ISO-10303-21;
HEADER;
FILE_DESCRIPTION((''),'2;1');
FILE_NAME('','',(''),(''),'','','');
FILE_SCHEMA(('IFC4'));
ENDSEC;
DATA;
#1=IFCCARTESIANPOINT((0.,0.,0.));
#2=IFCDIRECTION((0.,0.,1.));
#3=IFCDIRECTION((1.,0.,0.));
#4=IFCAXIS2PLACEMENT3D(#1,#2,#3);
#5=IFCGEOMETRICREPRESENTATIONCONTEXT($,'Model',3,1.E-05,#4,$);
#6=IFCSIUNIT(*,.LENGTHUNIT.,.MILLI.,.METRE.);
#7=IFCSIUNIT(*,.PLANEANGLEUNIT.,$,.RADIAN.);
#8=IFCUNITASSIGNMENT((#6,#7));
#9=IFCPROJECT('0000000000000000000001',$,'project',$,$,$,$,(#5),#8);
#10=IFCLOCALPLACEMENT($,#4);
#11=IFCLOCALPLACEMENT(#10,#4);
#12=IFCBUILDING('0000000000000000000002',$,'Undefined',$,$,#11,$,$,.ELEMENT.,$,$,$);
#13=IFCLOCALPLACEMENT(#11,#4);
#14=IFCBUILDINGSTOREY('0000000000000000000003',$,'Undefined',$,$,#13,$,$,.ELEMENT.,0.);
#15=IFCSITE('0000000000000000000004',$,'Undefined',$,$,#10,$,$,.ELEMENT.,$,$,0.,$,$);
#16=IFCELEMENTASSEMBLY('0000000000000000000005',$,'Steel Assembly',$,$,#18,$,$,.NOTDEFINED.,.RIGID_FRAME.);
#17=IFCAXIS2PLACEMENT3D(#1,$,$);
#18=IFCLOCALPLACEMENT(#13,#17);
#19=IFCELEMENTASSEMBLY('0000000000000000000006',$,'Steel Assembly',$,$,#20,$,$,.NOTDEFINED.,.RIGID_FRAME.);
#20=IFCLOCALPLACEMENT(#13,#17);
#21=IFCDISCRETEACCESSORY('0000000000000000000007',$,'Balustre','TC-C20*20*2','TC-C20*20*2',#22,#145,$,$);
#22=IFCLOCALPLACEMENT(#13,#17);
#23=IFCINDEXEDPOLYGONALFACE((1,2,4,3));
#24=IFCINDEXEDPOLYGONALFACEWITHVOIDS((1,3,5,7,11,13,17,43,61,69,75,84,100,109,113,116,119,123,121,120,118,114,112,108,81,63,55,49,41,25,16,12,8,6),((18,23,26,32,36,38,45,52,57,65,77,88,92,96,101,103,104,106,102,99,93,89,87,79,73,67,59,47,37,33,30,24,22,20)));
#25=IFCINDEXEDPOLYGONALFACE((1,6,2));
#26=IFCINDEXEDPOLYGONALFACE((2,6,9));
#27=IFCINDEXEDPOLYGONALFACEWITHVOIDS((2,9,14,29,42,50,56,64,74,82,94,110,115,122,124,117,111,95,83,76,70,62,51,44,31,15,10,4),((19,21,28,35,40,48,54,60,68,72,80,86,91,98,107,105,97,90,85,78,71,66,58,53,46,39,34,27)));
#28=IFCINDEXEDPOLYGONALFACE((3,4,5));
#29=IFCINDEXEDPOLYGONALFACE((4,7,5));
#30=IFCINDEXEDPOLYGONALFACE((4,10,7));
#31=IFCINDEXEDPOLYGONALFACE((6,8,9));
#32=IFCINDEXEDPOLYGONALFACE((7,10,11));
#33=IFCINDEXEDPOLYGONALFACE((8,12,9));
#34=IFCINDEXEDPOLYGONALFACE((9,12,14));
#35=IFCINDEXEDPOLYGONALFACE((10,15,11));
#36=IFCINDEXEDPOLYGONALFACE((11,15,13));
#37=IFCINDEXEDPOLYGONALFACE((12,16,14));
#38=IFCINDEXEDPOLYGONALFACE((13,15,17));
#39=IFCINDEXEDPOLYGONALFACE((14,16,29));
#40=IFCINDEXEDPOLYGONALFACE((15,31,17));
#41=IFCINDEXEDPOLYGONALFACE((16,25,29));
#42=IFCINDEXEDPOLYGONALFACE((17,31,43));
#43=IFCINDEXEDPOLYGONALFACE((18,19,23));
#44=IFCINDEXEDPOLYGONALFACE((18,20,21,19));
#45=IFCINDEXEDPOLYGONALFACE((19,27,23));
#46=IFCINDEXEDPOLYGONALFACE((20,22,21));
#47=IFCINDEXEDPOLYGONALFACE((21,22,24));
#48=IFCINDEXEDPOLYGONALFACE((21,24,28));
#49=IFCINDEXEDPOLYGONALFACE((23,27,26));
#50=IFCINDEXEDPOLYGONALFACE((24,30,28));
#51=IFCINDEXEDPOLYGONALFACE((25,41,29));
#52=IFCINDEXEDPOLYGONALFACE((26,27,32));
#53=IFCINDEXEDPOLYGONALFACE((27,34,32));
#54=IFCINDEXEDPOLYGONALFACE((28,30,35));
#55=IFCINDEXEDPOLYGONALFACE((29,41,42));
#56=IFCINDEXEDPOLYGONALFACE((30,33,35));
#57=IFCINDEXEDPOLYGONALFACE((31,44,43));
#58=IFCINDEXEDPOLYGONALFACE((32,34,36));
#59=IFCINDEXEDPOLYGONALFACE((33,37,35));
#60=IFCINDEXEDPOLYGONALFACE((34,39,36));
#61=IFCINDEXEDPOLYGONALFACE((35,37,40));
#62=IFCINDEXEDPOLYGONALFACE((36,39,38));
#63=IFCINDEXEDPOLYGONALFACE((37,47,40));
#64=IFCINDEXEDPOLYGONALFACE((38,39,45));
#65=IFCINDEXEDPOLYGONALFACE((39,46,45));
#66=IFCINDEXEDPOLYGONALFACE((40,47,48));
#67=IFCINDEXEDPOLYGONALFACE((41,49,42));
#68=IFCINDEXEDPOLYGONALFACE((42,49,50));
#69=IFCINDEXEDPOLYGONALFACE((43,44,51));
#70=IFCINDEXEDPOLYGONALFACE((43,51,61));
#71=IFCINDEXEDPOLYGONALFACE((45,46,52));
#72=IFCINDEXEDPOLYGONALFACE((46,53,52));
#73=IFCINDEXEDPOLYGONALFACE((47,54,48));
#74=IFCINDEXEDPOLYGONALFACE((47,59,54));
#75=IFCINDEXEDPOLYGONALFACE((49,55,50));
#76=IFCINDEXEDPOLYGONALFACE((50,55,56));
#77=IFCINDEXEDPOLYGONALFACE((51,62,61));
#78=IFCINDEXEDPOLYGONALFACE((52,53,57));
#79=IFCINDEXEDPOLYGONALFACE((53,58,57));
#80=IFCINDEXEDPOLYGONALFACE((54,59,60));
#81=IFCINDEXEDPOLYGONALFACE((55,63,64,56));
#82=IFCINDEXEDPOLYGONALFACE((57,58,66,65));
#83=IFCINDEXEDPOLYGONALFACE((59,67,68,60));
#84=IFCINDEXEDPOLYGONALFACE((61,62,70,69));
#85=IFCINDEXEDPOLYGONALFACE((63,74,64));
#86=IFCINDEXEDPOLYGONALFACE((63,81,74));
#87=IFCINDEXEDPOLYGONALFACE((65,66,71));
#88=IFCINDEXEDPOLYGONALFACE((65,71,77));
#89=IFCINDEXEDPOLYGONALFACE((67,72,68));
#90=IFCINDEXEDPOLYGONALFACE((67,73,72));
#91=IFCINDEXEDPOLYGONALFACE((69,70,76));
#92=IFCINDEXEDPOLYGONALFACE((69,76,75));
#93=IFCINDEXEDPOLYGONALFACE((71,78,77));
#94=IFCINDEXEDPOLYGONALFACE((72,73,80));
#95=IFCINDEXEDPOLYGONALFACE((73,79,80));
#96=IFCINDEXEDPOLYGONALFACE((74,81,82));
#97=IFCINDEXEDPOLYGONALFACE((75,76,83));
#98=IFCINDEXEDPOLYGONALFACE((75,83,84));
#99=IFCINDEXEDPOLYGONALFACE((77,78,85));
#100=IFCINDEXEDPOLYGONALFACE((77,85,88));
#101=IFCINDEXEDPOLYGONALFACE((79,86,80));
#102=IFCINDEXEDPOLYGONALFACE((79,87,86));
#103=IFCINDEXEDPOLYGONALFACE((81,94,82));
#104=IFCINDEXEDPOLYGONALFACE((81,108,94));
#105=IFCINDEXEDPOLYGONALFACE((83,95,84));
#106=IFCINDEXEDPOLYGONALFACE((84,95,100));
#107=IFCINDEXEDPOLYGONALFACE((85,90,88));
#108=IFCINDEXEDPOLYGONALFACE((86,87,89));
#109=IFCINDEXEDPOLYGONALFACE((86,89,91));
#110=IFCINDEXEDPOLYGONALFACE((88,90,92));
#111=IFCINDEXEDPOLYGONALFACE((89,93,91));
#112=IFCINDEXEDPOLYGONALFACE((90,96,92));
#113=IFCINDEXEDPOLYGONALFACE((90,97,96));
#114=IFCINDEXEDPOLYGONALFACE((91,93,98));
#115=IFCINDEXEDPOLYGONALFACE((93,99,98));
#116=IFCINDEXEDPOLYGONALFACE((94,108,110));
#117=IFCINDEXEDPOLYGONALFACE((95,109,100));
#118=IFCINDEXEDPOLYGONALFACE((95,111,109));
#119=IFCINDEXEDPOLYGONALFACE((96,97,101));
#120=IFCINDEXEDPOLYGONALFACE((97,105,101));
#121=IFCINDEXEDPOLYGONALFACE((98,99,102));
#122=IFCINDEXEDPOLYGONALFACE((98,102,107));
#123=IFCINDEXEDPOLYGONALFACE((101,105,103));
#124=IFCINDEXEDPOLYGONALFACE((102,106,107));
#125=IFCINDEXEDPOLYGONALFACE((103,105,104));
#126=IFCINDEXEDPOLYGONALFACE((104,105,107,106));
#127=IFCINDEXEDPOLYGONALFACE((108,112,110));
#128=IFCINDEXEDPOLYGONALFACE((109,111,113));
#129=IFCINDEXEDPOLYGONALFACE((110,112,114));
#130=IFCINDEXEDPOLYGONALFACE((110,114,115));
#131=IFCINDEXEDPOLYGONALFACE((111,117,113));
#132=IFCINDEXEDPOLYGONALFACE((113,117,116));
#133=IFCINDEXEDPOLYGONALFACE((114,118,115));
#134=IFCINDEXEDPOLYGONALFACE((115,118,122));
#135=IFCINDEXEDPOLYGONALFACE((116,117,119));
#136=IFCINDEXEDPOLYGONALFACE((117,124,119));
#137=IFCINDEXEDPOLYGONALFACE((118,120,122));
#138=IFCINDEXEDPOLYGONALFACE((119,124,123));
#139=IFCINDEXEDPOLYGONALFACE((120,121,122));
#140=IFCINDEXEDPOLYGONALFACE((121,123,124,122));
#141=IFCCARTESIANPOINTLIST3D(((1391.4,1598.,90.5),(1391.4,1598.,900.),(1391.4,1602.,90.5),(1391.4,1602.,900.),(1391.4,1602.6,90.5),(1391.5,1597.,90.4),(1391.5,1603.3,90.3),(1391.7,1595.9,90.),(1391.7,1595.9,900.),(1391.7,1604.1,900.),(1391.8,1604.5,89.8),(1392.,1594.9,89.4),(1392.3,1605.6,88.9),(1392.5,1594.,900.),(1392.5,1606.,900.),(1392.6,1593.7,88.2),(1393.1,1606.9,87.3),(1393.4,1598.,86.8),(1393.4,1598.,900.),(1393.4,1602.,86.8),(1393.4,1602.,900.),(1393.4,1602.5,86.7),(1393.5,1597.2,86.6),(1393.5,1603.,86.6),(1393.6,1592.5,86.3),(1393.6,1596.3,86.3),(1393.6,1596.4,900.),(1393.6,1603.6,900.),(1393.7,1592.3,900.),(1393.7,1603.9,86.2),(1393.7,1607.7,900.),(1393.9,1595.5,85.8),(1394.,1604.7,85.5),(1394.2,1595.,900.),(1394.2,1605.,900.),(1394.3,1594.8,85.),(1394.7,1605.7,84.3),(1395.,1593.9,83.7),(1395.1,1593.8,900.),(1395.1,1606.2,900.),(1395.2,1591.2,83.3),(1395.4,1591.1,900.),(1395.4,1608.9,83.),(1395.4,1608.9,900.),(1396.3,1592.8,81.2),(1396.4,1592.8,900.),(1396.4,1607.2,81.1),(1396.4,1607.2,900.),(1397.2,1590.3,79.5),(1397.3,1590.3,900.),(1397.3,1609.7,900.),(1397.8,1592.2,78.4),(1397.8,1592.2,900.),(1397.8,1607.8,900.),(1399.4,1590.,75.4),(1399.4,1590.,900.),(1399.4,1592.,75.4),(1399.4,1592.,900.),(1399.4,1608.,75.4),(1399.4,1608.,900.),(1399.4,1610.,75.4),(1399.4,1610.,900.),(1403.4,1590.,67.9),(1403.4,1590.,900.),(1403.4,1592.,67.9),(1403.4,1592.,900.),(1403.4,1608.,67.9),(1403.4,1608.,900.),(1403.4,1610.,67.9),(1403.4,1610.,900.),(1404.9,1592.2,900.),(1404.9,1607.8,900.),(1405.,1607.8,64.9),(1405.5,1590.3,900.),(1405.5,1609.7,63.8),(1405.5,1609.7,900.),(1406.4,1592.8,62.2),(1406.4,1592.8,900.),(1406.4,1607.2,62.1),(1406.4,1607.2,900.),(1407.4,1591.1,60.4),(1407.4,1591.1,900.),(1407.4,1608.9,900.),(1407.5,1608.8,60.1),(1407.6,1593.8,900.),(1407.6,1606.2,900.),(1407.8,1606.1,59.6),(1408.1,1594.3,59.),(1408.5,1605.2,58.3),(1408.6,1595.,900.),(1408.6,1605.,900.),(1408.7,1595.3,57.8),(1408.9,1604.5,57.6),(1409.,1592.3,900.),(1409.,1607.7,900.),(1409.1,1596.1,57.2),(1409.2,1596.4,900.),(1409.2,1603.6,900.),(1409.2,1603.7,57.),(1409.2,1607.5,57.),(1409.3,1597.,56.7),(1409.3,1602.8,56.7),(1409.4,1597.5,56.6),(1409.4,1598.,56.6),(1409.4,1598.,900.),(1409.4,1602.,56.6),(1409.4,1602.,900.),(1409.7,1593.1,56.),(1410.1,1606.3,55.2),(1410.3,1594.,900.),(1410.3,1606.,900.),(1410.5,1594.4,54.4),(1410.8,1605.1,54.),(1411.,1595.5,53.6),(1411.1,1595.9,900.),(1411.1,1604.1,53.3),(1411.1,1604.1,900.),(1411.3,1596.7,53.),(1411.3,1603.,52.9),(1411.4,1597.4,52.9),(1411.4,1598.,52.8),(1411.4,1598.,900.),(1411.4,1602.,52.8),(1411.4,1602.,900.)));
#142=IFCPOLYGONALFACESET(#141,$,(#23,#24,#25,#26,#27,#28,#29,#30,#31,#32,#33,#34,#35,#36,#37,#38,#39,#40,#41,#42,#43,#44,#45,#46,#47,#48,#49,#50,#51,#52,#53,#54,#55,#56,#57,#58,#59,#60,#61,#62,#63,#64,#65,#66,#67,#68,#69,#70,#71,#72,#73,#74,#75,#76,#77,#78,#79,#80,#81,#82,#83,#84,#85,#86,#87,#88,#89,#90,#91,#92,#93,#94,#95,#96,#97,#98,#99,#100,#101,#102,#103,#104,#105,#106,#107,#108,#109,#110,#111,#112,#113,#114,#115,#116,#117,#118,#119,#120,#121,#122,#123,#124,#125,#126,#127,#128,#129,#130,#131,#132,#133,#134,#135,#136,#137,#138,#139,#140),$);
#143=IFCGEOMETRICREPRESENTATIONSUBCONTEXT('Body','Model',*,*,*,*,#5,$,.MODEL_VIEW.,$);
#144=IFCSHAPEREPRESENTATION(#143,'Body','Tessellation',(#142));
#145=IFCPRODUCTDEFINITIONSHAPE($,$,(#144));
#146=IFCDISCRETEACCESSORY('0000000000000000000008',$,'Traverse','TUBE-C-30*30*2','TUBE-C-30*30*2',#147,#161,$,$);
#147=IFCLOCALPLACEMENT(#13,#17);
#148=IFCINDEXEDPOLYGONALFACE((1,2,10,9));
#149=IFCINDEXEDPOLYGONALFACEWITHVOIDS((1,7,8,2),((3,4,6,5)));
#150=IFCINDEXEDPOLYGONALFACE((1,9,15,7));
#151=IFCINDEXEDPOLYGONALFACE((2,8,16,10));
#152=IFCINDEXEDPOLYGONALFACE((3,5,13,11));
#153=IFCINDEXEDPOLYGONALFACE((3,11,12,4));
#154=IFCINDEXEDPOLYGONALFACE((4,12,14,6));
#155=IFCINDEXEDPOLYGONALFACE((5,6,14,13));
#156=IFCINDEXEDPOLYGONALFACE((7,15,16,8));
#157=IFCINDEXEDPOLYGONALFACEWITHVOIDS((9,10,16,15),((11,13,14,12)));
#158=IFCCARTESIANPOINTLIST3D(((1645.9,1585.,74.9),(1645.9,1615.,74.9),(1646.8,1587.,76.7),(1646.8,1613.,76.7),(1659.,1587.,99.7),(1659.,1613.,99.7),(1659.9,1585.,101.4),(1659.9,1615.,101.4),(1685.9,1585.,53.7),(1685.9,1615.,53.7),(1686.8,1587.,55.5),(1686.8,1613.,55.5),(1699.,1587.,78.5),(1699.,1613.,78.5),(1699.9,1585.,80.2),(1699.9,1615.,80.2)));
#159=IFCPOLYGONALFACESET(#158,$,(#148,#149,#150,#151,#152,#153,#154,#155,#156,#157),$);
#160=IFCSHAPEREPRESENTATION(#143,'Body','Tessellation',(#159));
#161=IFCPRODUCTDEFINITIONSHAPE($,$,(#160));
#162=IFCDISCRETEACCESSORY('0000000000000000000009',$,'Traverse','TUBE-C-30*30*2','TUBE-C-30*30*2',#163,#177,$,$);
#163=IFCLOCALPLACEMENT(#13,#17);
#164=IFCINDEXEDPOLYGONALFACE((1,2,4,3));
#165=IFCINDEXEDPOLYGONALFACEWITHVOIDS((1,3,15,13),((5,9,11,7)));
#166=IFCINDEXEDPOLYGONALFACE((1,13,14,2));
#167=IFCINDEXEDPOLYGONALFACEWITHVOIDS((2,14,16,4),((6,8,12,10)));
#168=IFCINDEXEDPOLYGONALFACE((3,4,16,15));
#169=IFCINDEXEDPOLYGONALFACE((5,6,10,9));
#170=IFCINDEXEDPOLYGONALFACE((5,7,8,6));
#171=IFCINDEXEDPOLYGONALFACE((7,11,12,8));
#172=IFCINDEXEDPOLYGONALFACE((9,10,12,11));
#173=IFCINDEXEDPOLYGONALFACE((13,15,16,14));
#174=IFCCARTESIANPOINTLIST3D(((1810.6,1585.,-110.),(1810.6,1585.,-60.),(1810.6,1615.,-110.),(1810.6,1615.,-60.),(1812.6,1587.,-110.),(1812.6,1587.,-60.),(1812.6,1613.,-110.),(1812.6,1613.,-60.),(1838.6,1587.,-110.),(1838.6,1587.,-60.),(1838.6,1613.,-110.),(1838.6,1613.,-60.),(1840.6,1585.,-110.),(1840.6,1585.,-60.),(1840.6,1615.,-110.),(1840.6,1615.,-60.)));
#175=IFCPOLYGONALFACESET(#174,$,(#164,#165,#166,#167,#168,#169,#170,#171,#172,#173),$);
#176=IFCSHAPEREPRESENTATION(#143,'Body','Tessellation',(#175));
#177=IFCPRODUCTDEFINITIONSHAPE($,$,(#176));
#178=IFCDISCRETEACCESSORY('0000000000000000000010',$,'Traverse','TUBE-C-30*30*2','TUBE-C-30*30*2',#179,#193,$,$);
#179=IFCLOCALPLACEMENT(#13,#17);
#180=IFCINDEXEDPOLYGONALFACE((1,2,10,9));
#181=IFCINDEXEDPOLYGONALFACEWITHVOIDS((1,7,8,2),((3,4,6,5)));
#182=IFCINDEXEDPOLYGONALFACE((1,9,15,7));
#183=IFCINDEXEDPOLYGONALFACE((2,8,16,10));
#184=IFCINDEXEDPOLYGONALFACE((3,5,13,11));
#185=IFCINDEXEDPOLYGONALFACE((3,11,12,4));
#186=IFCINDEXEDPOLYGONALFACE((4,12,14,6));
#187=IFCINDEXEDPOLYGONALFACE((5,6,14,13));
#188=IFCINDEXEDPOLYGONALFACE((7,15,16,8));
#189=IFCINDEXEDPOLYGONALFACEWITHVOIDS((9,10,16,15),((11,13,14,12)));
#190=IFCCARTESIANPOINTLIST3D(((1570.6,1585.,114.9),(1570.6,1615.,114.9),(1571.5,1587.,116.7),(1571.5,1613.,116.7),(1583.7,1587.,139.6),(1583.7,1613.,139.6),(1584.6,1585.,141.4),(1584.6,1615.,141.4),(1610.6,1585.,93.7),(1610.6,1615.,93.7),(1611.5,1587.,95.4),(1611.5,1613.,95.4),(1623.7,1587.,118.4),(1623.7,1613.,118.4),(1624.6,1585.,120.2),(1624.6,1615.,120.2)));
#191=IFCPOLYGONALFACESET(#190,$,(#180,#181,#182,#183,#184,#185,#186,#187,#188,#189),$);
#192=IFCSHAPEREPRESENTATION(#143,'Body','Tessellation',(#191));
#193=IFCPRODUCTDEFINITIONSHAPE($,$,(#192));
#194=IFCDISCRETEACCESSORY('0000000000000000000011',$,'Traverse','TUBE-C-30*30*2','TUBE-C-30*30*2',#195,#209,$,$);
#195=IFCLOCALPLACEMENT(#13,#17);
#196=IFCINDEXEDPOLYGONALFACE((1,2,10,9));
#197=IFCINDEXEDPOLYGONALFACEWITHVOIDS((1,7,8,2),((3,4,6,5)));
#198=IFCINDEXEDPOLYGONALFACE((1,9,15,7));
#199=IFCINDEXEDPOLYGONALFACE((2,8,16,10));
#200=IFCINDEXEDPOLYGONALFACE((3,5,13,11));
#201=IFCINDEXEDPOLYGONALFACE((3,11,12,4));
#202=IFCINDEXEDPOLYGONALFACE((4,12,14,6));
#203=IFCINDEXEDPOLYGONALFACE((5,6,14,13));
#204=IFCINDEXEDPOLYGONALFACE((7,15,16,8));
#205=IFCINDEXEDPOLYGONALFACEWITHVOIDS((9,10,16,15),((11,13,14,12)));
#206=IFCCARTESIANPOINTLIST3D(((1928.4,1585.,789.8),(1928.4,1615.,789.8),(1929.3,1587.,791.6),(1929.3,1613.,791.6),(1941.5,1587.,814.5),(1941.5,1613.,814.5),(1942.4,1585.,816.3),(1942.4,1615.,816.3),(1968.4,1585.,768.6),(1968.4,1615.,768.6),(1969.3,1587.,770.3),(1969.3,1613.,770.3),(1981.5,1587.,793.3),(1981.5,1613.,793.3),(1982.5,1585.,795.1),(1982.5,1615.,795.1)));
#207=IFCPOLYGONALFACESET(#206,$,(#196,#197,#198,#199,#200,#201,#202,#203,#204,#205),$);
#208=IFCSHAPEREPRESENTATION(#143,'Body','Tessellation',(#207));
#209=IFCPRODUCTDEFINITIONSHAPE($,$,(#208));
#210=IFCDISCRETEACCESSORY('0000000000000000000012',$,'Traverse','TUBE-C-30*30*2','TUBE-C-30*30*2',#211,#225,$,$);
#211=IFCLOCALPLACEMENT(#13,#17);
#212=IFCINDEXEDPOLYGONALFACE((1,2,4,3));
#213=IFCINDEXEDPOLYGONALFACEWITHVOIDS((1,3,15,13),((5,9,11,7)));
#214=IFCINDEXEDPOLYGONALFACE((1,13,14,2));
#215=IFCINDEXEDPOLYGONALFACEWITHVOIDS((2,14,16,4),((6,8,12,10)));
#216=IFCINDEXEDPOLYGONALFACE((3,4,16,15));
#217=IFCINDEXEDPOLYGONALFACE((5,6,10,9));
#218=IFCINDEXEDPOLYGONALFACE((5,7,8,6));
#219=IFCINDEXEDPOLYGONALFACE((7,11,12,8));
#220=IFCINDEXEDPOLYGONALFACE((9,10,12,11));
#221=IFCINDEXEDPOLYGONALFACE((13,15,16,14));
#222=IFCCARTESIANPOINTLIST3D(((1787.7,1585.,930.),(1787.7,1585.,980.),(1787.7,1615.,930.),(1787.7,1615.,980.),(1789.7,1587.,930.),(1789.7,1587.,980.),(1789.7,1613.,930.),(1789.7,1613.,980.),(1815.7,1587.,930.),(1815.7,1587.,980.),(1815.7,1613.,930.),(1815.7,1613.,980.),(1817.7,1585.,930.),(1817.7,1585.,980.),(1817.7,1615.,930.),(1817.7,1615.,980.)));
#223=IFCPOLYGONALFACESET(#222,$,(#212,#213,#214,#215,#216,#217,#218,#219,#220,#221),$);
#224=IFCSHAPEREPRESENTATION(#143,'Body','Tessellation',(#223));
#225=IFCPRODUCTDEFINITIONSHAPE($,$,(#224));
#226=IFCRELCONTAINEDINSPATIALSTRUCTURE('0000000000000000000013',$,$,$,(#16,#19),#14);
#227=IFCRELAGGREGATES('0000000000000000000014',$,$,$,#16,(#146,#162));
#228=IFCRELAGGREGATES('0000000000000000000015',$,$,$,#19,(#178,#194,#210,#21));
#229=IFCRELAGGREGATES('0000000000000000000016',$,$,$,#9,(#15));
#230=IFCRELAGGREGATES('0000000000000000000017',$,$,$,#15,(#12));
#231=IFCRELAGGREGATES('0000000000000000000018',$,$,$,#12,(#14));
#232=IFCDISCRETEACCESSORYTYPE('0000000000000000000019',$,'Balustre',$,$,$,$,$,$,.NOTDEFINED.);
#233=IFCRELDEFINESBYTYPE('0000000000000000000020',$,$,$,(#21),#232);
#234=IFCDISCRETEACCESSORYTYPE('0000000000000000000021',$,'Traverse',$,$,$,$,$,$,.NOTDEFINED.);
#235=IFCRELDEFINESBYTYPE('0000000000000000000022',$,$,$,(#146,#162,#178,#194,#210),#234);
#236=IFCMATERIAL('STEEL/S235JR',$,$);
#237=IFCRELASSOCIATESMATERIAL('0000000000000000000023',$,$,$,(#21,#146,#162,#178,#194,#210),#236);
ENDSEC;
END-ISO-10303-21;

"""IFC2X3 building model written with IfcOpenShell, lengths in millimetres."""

from ifc_helpers import new_model, si_unit, frame, origin_with_axes, origin_2d_with_axis, place, context, subcontext, project, spatial, hollow_rectangle, extrude, clip, halfspace, material, type_object, element, aggregate, save


model = new_model("IFC2X3")

# Units and contexts
model_context = context("Model", 3, precision=1e-05, world=origin_with_axes())
body_context = subcontext(model_context, "Body", "Model", "MODEL_VIEW")
ifc_project = project(units=[si_unit("LENGTHUNIT", "METRE", prefix="MILLI"), si_unit("PLANEANGLEUNIT", "RADIAN")], contexts=[model_context])

# Site, building, storey
site_placement = place(None, origin_with_axes())
site = spatial("IfcSite", under=ifc_project, at=site_placement, Name="Undefined", CompositionType="ELEMENT", RefElevation=0.0)
building_placement = place(site_placement, origin_with_axes())
building = spatial("IfcBuilding", under=site, at=building_placement, Name="Undefined", CompositionType="ELEMENT")
storey_placement = place(building_placement, origin_with_axes())
storey = spatial("IfcBuildingStorey", under=building, at=storey_placement, Name="Undefined", CompositionType="ELEMENT", Elevation=0.0)

# Element assemblies
assembly_1_placement = place(storey_placement, origin_with_axes())
assembly_1 = element("IfcElementAssembly", 1, at=assembly_1_placement, inside=storey, Name="Steel Assembly", AssemblyPlace="NOTDEFINED", PredefinedType="RIGID_FRAME")
ifc_material = material(Name="STEEL/S235JR")
assembly_2_placement = place(storey_placement, origin_with_axes())
assembly_2 = element("IfcElementAssembly", 2, at=assembly_2_placement, inside=storey, Name="Steel Assembly", AssemblyPlace="NOTDEFINED", PredefinedType="RIGID_FRAME")

# Discrete accessories
discrete_accessory_type_1 = type_object("IfcDiscreteAccessoryType", Name="Balustre")
discrete_accessory_1_placement = place(assembly_2_placement, frame((1401.4, 1600.0, 900.0), z_axis=(0.0, 1.0, 0.0), x_axis=(0.0, 0.0, -1.0)))
discrete_accessory_1 = element("IfcDiscreteAccessory", 3, at=discrete_accessory_1_placement, type_object=discrete_accessory_type_1, material=ifc_material, Name="Balustre", Description="TC-C20*20*2", ObjectType="TC-C20*20*2", context=body_context, shape_type="Clipping", body=[
    clip(extrude(hollow_rectangle(XDim=20.0, YDim=20.0, WallThickness=2.0, InnerFilletRadius=6.0, OuterFilletRadius=8.0, at=origin_2d_with_axis()), frame((847.4, 0.0, 0.0), z_axis=(-1.0, 0.0, 0.0), x_axis=(0.0, -1.0, 0.0)), (0.0, 0.0, 1.0), 847.4), halfspace(frame((285.4, 287.9, 0.0), z_axis=(-0.46842, -0.883506, 0.000005), x_axis=(0.0, 0.000005, 1.0)), True)),
])
discrete_accessory_type_2 = type_object("IfcDiscreteAccessoryType", Name="Traverse")
discrete_accessory_2_placement = place(assembly_1_placement, frame((1692.9, 1600.0, 67.0), z_axis=(-0.000011, 1.0, 0.0), x_axis=(-0.883506, -0.00001, 0.46842)))
discrete_accessory_2 = element("IfcDiscreteAccessory", 4, at=discrete_accessory_2_placement, type_object=discrete_accessory_type_2, material=ifc_material, Name="Traverse", Description="TUBE-C-30*30*2", ObjectType="TUBE-C-30*30*2", context=body_context, shape_type="SweptSolid", body=[
    extrude(hollow_rectangle(XDim=30.0, YDim=30.0, WallThickness=2.0, at=origin_2d_with_axis()), frame((45.3, 0.0, 0.0), z_axis=(-1.0, 0.0, 0.0), x_axis=(0.0, -1.0, 0.0)), (0.0, 0.0, 1.0), 45.3),
])
discrete_accessory_3_placement = place(assembly_1_placement, frame((1825.6, 1600.0, -60.0), z_axis=(-0.000011, 1.0, 0.0), x_axis=(0.0, 0.0, -1.0)))
discrete_accessory_3 = element("IfcDiscreteAccessory", 5, at=discrete_accessory_3_placement, type_object=discrete_accessory_type_2, material=ifc_material, Name="Traverse", Description="TUBE-C-30*30*2", ObjectType="TUBE-C-30*30*2", context=body_context, shape_type="SweptSolid", body=[
    extrude(hollow_rectangle(XDim=30.0, YDim=30.0, WallThickness=2.0, at=origin_2d_with_axis()), frame((50.0, 0.0, 0.0), z_axis=(-1.0, 0.0, 0.0), x_axis=(0.0, -1.0, 0.0)), (0.0, 0.0, 1.0), 50.0),
])
aggregate(assembly_1, [discrete_accessory_2, discrete_accessory_3])
discrete_accessory_4_placement = place(assembly_2_placement, frame((1577.6, 1600.0, 128.2), z_axis=(0.0, 1.0, 0.0), x_axis=(0.883506, 0.0, -0.46842)))
discrete_accessory_4 = element("IfcDiscreteAccessory", 6, at=discrete_accessory_4_placement, type_object=discrete_accessory_type_2, material=ifc_material, Name="Traverse", Description="TUBE-C-30*30*2", ObjectType="TUBE-C-30*30*2", context=body_context, shape_type="SweptSolid", body=[
    extrude(hollow_rectangle(XDim=30.0, YDim=30.0, WallThickness=2.0, at=origin_2d_with_axis()), frame((45.3, 0.0, 0.0), z_axis=(-1.0, 0.0, 0.0), x_axis=(0.0, -1.0, 0.0)), (0.0, 0.0, 1.0), 45.3),
])
discrete_accessory_5_placement = place(assembly_2_placement, frame((1935.4, 1600.0, 803.0), z_axis=(0.0, 1.0, 0.0), x_axis=(0.883506, 0.0, -0.46842)))
discrete_accessory_5 = element("IfcDiscreteAccessory", 7, at=discrete_accessory_5_placement, type_object=discrete_accessory_type_2, material=ifc_material, Name="Traverse", Description="TUBE-C-30*30*2", ObjectType="TUBE-C-30*30*2", context=body_context, shape_type="SweptSolid", body=[
    extrude(hollow_rectangle(XDim=30.0, YDim=30.0, WallThickness=2.0, at=origin_2d_with_axis()), frame((45.3, 0.0, 0.0), z_axis=(-1.0, 0.0, 0.0), x_axis=(0.0, -1.0, 0.0)), (0.0, 0.0, 1.0), 45.3),
])
discrete_accessory_6_placement = place(assembly_2_placement, frame((1802.7, 1600.0, 930.0), z_axis=(0.0, 0.0, 1.0), x_axis=(1.0, 0.0, 0.0)))
discrete_accessory_6 = element("IfcDiscreteAccessory", 8, at=discrete_accessory_6_placement, type_object=discrete_accessory_type_2, material=ifc_material, Name="Traverse", Description="TUBE-C-30*30*2", ObjectType="TUBE-C-30*30*2", context=body_context, shape_type="SweptSolid", body=[
    extrude(hollow_rectangle(XDim=30.0, YDim=30.0, WallThickness=2.0, at=origin_2d_with_axis()), frame((0.0, 0.0, 50.0), z_axis=(0.0, 0.0, -1.0), x_axis=(-1.0, 0.0, 0.0)), (0.0, 0.0, 1.0), 50.0),
])
aggregate(assembly_2, [discrete_accessory_4, discrete_accessory_5, discrete_accessory_6, discrete_accessory_1])

save(model, "model.ifc")
